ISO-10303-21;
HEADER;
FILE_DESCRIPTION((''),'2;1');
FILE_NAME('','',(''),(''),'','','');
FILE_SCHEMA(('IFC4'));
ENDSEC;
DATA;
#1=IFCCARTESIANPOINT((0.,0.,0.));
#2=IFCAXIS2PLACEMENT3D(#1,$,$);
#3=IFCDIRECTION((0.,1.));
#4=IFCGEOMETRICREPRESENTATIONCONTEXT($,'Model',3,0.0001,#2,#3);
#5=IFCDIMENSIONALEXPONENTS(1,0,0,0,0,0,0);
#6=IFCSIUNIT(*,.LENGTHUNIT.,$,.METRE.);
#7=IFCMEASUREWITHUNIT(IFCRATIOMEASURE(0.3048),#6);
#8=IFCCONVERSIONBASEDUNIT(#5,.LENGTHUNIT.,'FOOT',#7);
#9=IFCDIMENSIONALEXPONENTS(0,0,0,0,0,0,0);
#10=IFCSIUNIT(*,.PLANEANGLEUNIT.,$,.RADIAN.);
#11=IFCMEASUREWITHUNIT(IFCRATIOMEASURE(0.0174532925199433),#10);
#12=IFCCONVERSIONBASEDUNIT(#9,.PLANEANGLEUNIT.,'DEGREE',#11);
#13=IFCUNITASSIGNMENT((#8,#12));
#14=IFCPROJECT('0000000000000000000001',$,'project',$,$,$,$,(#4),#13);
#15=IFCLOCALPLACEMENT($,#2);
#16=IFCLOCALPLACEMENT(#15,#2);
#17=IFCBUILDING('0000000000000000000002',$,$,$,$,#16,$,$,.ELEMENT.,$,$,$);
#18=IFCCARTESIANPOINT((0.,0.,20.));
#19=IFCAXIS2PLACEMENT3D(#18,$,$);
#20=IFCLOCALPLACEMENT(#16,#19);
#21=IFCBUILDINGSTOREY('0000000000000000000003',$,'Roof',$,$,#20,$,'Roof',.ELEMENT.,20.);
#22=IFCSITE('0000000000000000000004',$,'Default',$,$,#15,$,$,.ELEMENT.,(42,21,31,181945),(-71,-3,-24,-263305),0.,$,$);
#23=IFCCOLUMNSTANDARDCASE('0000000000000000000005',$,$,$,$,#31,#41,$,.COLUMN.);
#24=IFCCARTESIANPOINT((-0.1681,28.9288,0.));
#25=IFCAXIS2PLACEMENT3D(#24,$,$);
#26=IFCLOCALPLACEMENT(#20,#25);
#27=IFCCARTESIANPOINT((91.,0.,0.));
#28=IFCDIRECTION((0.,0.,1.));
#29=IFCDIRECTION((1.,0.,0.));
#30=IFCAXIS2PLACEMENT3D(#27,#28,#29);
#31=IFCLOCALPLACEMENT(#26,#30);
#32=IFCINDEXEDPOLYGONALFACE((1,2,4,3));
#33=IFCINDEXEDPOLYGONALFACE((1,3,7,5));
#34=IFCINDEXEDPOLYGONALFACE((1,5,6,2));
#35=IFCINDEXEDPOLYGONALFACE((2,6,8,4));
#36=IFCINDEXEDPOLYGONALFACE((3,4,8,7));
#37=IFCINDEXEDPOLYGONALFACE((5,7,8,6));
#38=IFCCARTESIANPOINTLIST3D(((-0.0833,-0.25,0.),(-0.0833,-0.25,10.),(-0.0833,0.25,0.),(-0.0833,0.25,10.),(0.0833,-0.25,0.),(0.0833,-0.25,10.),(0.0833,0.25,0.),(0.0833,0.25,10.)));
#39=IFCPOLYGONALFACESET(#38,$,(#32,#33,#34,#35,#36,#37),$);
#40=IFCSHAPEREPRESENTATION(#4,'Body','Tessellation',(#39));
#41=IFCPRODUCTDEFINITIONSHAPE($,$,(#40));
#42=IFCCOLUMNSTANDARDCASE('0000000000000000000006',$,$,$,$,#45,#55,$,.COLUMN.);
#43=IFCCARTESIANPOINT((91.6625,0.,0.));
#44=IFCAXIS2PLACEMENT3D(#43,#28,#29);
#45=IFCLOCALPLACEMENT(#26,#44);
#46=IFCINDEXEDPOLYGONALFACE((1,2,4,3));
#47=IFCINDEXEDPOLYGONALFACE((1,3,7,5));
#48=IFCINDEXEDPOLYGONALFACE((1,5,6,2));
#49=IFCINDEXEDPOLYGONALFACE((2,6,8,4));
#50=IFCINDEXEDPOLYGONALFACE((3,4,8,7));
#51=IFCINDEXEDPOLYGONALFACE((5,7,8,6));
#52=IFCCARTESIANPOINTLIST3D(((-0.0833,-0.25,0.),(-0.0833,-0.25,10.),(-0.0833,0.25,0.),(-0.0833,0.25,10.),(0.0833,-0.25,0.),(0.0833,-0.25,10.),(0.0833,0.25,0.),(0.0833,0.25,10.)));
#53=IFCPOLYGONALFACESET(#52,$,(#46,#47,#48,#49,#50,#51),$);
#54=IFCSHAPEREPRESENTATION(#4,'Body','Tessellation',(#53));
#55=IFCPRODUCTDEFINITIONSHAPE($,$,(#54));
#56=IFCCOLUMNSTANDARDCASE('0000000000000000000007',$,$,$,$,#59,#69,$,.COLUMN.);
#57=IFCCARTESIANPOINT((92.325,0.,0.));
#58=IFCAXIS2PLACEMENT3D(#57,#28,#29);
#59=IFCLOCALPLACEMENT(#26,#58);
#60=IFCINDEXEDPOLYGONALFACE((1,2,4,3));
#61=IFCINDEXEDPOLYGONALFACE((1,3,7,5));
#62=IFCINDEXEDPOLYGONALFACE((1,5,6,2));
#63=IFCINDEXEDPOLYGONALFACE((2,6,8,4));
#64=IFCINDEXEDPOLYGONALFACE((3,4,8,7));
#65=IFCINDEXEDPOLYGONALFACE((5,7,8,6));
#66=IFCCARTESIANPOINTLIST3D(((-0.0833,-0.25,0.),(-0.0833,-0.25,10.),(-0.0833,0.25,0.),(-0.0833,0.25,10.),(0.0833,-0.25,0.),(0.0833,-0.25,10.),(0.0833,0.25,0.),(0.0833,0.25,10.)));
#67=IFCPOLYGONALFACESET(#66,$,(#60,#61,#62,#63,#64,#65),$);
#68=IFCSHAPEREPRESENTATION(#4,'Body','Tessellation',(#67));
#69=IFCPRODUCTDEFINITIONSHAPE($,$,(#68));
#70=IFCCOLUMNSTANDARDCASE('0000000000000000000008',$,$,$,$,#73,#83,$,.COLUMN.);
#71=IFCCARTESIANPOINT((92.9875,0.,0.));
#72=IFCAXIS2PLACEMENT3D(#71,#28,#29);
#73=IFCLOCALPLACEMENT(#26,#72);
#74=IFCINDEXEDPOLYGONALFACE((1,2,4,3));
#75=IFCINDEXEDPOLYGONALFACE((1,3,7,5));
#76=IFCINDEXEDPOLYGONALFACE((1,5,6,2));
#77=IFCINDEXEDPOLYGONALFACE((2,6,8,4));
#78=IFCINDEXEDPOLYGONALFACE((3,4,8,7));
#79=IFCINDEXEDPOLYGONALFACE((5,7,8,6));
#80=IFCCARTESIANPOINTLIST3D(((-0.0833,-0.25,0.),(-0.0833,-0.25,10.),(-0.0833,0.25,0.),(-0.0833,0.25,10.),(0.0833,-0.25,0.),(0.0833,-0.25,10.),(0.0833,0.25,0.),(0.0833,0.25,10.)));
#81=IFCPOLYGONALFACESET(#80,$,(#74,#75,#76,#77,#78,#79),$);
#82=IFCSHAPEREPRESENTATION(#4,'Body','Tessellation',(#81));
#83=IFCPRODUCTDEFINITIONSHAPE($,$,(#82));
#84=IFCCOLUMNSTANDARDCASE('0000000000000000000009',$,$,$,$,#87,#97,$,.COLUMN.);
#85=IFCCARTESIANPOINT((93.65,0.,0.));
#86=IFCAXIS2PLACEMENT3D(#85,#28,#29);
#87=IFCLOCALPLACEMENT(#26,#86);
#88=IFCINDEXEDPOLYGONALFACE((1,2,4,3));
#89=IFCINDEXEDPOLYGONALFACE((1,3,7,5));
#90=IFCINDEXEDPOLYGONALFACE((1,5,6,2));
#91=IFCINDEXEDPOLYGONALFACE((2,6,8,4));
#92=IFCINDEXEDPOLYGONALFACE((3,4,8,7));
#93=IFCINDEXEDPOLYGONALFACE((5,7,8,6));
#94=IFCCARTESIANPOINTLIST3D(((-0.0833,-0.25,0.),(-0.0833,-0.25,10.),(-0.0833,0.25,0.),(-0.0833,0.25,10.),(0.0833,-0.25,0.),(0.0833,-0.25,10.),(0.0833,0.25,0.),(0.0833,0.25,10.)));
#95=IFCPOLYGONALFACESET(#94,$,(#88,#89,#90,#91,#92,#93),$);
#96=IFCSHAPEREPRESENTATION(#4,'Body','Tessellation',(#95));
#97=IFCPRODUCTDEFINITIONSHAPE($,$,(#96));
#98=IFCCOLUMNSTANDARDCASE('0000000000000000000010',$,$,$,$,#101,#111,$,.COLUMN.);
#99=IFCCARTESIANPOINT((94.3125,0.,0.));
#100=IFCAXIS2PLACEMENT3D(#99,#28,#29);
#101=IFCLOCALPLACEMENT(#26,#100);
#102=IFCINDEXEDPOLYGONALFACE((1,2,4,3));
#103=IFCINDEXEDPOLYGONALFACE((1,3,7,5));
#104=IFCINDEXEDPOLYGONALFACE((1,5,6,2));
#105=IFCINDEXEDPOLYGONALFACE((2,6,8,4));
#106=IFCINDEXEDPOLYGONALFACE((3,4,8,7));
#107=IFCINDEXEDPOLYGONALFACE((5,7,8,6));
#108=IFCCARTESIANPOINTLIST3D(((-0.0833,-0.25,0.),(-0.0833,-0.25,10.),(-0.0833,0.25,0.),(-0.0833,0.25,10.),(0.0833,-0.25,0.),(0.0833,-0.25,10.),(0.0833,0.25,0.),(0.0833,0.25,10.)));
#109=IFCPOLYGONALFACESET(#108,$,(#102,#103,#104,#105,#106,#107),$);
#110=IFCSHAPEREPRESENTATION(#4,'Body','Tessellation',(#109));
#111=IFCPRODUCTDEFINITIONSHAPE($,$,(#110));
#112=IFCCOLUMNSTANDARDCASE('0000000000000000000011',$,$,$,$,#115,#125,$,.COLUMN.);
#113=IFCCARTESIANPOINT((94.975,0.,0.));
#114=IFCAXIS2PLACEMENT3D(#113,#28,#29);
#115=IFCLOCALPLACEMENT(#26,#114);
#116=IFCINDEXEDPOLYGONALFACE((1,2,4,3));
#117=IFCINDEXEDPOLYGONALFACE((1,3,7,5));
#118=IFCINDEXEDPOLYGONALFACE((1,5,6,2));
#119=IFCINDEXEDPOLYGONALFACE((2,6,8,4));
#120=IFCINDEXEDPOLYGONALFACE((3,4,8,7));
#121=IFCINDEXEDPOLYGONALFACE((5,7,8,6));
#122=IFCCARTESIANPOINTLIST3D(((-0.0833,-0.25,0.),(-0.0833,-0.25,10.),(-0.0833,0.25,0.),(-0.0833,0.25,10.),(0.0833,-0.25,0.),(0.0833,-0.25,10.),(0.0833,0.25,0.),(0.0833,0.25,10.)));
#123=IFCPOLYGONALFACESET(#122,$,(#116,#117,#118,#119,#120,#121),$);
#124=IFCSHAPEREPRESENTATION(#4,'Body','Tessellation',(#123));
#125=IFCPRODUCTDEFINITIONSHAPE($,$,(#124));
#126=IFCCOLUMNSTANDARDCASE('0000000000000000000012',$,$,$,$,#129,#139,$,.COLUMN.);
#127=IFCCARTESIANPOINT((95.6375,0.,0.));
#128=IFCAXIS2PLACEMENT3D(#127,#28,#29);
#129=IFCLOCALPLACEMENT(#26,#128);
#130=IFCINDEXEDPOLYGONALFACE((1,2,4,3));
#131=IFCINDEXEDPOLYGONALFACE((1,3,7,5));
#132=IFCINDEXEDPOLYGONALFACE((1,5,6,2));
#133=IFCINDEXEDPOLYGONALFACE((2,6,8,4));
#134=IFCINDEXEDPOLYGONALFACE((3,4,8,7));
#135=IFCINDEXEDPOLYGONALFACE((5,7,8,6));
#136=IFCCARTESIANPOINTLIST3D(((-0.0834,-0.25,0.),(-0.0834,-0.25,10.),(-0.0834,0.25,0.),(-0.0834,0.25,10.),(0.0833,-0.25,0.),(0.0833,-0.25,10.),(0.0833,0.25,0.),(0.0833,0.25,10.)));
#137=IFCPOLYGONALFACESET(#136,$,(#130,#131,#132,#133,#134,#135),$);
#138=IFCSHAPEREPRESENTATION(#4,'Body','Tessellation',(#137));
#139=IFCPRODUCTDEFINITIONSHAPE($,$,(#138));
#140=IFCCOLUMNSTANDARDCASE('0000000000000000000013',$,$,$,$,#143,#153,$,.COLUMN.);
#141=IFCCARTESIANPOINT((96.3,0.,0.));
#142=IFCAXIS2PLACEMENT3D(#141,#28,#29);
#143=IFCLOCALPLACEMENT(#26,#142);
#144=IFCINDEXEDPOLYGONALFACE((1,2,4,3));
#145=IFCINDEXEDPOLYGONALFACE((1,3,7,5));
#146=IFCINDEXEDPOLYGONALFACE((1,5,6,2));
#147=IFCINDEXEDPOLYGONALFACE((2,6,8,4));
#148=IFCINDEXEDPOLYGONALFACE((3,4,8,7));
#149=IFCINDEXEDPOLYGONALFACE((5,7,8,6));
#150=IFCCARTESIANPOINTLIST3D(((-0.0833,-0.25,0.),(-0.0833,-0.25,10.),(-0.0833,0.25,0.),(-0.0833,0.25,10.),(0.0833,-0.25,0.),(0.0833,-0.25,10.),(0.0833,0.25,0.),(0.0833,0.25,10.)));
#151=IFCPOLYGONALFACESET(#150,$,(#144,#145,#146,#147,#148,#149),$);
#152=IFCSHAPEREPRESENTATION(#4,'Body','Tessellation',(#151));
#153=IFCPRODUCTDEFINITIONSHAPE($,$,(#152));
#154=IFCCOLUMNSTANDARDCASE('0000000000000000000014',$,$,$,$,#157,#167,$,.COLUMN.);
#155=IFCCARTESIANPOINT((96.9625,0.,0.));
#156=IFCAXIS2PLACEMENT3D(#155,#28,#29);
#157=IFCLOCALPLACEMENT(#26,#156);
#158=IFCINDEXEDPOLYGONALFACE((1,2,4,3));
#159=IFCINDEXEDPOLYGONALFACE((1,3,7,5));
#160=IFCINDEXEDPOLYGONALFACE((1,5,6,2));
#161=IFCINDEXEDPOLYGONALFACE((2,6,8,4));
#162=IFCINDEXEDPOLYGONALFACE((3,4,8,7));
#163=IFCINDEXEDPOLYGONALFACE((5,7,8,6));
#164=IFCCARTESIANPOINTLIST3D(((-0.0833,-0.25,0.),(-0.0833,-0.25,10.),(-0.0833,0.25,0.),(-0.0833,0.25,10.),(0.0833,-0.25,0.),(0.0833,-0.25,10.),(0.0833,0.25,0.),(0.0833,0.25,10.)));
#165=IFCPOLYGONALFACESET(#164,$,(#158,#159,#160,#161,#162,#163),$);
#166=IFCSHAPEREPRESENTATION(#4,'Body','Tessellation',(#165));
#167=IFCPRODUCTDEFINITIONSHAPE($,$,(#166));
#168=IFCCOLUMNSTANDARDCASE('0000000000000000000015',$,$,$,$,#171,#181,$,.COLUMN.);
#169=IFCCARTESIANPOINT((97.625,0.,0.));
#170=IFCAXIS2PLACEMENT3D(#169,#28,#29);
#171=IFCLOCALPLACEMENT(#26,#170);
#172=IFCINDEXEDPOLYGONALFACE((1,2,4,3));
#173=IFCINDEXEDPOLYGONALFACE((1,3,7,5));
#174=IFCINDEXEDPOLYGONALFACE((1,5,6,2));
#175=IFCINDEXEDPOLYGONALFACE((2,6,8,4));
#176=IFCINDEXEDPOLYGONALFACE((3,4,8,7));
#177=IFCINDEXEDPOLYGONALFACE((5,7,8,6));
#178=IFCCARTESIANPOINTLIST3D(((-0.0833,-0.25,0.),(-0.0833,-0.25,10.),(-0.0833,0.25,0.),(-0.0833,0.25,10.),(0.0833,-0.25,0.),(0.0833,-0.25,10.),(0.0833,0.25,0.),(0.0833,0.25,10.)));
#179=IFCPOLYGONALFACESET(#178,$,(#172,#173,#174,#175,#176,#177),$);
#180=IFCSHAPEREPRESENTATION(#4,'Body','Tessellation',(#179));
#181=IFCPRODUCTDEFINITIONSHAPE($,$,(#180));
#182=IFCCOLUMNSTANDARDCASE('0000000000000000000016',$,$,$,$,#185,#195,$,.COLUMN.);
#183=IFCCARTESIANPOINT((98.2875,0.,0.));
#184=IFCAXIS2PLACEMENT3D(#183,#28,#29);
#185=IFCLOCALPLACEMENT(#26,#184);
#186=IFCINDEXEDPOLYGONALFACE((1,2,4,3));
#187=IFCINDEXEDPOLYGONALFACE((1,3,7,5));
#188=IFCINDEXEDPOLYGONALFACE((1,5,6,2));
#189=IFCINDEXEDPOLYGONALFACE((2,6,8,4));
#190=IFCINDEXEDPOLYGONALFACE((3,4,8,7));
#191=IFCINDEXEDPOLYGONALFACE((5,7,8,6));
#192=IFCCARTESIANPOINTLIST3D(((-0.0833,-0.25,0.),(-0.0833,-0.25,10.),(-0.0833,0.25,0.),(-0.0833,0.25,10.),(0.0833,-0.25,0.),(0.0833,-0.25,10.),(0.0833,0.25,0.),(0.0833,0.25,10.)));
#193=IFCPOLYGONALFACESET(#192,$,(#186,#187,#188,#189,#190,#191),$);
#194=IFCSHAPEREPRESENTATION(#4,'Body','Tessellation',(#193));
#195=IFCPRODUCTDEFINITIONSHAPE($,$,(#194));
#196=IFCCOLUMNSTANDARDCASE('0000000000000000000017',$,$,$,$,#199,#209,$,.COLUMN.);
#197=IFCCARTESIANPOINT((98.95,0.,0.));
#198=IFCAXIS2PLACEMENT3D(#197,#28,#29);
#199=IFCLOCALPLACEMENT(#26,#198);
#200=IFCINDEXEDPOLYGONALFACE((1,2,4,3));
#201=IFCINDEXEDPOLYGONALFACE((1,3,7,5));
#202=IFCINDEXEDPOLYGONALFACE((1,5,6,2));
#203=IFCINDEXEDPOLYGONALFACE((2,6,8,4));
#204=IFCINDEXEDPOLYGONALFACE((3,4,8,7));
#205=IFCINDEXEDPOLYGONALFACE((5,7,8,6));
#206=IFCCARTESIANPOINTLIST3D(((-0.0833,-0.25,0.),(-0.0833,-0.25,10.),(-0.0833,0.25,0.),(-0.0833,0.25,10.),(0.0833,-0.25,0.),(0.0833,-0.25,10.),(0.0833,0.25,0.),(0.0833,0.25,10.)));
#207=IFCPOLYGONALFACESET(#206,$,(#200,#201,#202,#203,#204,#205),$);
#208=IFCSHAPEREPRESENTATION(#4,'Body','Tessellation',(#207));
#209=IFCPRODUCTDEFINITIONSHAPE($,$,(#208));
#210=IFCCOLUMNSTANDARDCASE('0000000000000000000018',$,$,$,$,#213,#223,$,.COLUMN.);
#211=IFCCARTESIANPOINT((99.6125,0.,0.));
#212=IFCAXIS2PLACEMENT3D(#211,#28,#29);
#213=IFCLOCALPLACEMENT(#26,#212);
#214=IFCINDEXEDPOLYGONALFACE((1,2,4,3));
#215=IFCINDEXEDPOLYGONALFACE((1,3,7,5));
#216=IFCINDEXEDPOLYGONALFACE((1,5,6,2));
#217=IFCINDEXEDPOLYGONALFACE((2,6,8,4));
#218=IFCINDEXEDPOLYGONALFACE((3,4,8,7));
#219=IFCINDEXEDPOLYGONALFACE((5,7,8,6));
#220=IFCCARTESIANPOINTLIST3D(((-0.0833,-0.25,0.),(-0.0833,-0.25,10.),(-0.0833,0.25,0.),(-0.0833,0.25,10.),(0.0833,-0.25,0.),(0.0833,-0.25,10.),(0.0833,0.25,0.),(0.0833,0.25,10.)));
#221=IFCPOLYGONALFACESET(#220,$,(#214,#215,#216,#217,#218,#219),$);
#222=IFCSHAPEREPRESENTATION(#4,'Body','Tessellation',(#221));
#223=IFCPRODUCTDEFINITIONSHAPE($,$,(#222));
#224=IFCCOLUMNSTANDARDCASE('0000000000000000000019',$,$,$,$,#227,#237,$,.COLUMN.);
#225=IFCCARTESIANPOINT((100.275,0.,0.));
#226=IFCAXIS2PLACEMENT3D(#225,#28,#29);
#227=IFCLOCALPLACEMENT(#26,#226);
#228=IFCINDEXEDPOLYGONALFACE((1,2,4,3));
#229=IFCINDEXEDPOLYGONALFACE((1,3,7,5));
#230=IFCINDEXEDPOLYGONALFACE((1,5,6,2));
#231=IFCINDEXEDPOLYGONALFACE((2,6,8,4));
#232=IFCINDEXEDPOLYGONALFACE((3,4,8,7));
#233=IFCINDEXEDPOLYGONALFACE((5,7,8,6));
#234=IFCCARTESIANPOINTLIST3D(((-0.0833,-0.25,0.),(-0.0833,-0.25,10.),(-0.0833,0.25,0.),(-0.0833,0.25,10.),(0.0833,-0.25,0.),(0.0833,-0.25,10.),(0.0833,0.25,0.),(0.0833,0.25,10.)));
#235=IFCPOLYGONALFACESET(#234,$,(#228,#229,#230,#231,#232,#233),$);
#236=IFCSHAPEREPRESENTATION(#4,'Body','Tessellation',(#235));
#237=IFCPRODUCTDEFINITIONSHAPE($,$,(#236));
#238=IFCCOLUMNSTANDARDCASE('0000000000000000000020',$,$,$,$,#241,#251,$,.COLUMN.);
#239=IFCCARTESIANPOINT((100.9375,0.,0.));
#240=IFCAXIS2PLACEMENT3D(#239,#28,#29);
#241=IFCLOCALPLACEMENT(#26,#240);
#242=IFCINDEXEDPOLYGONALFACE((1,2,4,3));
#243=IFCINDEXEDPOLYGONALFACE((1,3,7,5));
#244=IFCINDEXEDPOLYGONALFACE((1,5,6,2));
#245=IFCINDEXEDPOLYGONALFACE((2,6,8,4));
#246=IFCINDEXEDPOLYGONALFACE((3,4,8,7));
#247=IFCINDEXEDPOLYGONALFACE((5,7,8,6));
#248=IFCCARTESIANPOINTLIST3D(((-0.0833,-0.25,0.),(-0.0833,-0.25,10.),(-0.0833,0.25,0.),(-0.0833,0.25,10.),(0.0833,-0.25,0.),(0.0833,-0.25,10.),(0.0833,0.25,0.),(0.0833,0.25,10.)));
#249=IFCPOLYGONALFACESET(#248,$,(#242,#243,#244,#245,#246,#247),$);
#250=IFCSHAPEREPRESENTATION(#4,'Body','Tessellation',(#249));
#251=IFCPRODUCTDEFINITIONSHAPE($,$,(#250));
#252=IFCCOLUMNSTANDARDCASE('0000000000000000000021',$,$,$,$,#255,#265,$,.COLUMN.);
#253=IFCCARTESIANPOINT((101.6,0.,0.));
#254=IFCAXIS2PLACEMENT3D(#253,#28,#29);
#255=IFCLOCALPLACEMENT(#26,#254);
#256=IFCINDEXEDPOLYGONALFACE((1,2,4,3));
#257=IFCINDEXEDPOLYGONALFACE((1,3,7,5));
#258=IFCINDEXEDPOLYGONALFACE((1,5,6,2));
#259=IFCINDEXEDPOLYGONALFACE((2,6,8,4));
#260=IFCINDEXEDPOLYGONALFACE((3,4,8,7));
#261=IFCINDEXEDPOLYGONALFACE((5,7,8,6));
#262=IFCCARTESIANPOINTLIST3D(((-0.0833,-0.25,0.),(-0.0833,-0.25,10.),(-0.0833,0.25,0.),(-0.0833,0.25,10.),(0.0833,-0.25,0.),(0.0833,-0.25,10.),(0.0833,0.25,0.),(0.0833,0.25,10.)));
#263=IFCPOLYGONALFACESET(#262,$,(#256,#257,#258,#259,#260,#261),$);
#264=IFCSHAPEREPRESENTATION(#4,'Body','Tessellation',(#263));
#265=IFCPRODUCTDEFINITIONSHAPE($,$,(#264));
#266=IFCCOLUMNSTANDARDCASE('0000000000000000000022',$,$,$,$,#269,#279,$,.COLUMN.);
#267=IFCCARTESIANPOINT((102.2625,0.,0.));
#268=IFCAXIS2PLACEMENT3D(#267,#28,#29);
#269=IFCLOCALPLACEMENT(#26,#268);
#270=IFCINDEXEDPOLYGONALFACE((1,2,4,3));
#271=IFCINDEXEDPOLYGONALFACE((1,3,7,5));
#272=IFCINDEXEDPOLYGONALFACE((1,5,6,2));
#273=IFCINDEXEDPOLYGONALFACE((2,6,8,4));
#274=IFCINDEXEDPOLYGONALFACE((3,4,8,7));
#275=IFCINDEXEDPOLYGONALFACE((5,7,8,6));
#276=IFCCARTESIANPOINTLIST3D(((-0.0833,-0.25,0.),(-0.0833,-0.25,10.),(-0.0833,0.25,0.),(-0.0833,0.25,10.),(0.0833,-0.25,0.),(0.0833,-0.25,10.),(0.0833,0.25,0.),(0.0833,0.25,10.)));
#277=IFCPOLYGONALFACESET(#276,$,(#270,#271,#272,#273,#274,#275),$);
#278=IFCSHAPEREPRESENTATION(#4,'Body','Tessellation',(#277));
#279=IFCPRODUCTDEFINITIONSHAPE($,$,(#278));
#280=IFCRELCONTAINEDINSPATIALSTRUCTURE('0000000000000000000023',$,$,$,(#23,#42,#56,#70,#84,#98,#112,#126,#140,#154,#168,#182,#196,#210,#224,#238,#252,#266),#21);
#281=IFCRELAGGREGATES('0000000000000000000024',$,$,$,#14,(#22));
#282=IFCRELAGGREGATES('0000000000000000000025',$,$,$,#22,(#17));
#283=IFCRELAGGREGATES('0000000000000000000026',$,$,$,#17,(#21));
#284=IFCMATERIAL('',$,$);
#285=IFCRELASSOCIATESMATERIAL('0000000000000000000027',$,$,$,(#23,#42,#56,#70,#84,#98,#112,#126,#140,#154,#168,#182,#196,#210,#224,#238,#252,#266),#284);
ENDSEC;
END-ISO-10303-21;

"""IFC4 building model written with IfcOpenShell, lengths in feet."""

from ifc_helpers import new_model, entity, si_unit, converted_unit, direction, frame, origin, place, context, project, spatial, rectangle, extrude, material, element, save


model = new_model("IFC4")

# Units and contexts
model_context = context("Model", 3, precision=0.0001, world=origin(), true_north=direction((0.0, 1.0)))
ifc_project = project(units=[converted_unit("LENGTHUNIT", "FOOT", entity("IfcRatioMeasure", 0.3048), si_unit("LENGTHUNIT", "METRE"), dimensions=[1, 0, 0, 0, 0, 0, 0]), converted_unit("PLANEANGLEUNIT", "DEGREE", entity("IfcRatioMeasure", 0.0174532925199433), si_unit("PLANEANGLEUNIT", "RADIAN"), dimensions=[0, 0, 0, 0, 0, 0, 0])], contexts=[model_context])

# Site, building, storey
site_placement = place(None, origin())
site = spatial("IfcSite", under=ifc_project, at=site_placement, Name="Default", CompositionType="ELEMENT", RefLatitude=(42, 21, 31, 181945), RefLongitude=(-71, -3, -24, -263305), RefElevation=0.0)
building_placement = place(site_placement, origin())
building = spatial("IfcBuilding", under=site, at=building_placement, CompositionType="ELEMENT")
storey_placement = place(building_placement, frame((0.0, 0.0, 20.0)))
storey = spatial("IfcBuildingStorey", under=building, at=storey_placement, Name="Roof", LongName="Roof", CompositionType="ELEMENT", Elevation=20.0)

# Columns
ifc_material_1 = material(Name="")
placement = place(storey_placement, frame((-0.1681, 28.9288, 0.0)))
for number, where, z_axis, x_axis in (
    (1, (91.0, 0.0, 0.0), (0.0, 0.0, 1.0), (1.0, 0.0, 0.0)),
    (2, (91.6625, 0.0, 0.0), (0.0, 0.0, 1.0), (1.0, 0.0, 0.0)),
    (3, (92.325, 0.0, 0.0), (0.0, 0.0, 1.0), (1.0, 0.0, 0.0)),
    (4, (92.9875, 0.0, 0.0), (0.0, 0.0, 1.0), (1.0, 0.0, 0.0)),
    (5, (93.65, 0.0, 0.0), (0.0, 0.0, 1.0), (1.0, 0.0, 0.0)),
    (6, (94.3125, 0.0, 0.0), (0.0, 0.0, 1.0), (1.0, 0.0, 0.0)),
    (7, (94.975, 0.0, 0.0), (0.0, 0.0, 1.0), (1.0, 0.0, 0.0)),
    (8, (95.6375, 0.0, 0.0), (0.0, 0.0, 1.0), (1.0, 0.0, 0.0)),
    (9, (96.3, 0.0, 0.0), (0.0, 0.0, 1.0), (1.0, 0.0, 0.0)),
    (10, (96.9625, 0.0, 0.0), (0.0, 0.0, 1.0), (1.0, 0.0, 0.0)),
    (11, (97.625, 0.0, 0.0), (0.0, 0.0, 1.0), (1.0, 0.0, 0.0)),
    (12, (98.2875, 0.0, 0.0), (0.0, 0.0, 1.0), (1.0, 0.0, 0.0)),
    (13, (98.95, 0.0, 0.0), (0.0, 0.0, 1.0), (1.0, 0.0, 0.0)),
    (14, (99.6125, 0.0, 0.0), (0.0, 0.0, 1.0), (1.0, 0.0, 0.0)),
    (15, (100.275, 0.0, 0.0), (0.0, 0.0, 1.0), (1.0, 0.0, 0.0)),
    (16, (100.9375, 0.0, 0.0), (0.0, 0.0, 1.0), (1.0, 0.0, 0.0)),
    (17, (101.6, 0.0, 0.0), (0.0, 0.0, 1.0), (1.0, 0.0, 0.0)),
    (18, (102.2625, 0.0, 0.0), (0.0, 0.0, 1.0), (1.0, 0.0, 0.0)),
):
    element("IfcColumnStandardCase", number, at=place(placement, frame(where, z_axis=z_axis, x_axis=x_axis)), inside=storey, material=ifc_material_1, PredefinedType="COLUMN", context=model_context, shape_type="SweptSolid", body=[
        extrude(rectangle(XDim=0.1667, YDim=0.5), origin(), (0.0, 0.0, 1.0), 10.0),
    ])

save(model, "model.ifc")
